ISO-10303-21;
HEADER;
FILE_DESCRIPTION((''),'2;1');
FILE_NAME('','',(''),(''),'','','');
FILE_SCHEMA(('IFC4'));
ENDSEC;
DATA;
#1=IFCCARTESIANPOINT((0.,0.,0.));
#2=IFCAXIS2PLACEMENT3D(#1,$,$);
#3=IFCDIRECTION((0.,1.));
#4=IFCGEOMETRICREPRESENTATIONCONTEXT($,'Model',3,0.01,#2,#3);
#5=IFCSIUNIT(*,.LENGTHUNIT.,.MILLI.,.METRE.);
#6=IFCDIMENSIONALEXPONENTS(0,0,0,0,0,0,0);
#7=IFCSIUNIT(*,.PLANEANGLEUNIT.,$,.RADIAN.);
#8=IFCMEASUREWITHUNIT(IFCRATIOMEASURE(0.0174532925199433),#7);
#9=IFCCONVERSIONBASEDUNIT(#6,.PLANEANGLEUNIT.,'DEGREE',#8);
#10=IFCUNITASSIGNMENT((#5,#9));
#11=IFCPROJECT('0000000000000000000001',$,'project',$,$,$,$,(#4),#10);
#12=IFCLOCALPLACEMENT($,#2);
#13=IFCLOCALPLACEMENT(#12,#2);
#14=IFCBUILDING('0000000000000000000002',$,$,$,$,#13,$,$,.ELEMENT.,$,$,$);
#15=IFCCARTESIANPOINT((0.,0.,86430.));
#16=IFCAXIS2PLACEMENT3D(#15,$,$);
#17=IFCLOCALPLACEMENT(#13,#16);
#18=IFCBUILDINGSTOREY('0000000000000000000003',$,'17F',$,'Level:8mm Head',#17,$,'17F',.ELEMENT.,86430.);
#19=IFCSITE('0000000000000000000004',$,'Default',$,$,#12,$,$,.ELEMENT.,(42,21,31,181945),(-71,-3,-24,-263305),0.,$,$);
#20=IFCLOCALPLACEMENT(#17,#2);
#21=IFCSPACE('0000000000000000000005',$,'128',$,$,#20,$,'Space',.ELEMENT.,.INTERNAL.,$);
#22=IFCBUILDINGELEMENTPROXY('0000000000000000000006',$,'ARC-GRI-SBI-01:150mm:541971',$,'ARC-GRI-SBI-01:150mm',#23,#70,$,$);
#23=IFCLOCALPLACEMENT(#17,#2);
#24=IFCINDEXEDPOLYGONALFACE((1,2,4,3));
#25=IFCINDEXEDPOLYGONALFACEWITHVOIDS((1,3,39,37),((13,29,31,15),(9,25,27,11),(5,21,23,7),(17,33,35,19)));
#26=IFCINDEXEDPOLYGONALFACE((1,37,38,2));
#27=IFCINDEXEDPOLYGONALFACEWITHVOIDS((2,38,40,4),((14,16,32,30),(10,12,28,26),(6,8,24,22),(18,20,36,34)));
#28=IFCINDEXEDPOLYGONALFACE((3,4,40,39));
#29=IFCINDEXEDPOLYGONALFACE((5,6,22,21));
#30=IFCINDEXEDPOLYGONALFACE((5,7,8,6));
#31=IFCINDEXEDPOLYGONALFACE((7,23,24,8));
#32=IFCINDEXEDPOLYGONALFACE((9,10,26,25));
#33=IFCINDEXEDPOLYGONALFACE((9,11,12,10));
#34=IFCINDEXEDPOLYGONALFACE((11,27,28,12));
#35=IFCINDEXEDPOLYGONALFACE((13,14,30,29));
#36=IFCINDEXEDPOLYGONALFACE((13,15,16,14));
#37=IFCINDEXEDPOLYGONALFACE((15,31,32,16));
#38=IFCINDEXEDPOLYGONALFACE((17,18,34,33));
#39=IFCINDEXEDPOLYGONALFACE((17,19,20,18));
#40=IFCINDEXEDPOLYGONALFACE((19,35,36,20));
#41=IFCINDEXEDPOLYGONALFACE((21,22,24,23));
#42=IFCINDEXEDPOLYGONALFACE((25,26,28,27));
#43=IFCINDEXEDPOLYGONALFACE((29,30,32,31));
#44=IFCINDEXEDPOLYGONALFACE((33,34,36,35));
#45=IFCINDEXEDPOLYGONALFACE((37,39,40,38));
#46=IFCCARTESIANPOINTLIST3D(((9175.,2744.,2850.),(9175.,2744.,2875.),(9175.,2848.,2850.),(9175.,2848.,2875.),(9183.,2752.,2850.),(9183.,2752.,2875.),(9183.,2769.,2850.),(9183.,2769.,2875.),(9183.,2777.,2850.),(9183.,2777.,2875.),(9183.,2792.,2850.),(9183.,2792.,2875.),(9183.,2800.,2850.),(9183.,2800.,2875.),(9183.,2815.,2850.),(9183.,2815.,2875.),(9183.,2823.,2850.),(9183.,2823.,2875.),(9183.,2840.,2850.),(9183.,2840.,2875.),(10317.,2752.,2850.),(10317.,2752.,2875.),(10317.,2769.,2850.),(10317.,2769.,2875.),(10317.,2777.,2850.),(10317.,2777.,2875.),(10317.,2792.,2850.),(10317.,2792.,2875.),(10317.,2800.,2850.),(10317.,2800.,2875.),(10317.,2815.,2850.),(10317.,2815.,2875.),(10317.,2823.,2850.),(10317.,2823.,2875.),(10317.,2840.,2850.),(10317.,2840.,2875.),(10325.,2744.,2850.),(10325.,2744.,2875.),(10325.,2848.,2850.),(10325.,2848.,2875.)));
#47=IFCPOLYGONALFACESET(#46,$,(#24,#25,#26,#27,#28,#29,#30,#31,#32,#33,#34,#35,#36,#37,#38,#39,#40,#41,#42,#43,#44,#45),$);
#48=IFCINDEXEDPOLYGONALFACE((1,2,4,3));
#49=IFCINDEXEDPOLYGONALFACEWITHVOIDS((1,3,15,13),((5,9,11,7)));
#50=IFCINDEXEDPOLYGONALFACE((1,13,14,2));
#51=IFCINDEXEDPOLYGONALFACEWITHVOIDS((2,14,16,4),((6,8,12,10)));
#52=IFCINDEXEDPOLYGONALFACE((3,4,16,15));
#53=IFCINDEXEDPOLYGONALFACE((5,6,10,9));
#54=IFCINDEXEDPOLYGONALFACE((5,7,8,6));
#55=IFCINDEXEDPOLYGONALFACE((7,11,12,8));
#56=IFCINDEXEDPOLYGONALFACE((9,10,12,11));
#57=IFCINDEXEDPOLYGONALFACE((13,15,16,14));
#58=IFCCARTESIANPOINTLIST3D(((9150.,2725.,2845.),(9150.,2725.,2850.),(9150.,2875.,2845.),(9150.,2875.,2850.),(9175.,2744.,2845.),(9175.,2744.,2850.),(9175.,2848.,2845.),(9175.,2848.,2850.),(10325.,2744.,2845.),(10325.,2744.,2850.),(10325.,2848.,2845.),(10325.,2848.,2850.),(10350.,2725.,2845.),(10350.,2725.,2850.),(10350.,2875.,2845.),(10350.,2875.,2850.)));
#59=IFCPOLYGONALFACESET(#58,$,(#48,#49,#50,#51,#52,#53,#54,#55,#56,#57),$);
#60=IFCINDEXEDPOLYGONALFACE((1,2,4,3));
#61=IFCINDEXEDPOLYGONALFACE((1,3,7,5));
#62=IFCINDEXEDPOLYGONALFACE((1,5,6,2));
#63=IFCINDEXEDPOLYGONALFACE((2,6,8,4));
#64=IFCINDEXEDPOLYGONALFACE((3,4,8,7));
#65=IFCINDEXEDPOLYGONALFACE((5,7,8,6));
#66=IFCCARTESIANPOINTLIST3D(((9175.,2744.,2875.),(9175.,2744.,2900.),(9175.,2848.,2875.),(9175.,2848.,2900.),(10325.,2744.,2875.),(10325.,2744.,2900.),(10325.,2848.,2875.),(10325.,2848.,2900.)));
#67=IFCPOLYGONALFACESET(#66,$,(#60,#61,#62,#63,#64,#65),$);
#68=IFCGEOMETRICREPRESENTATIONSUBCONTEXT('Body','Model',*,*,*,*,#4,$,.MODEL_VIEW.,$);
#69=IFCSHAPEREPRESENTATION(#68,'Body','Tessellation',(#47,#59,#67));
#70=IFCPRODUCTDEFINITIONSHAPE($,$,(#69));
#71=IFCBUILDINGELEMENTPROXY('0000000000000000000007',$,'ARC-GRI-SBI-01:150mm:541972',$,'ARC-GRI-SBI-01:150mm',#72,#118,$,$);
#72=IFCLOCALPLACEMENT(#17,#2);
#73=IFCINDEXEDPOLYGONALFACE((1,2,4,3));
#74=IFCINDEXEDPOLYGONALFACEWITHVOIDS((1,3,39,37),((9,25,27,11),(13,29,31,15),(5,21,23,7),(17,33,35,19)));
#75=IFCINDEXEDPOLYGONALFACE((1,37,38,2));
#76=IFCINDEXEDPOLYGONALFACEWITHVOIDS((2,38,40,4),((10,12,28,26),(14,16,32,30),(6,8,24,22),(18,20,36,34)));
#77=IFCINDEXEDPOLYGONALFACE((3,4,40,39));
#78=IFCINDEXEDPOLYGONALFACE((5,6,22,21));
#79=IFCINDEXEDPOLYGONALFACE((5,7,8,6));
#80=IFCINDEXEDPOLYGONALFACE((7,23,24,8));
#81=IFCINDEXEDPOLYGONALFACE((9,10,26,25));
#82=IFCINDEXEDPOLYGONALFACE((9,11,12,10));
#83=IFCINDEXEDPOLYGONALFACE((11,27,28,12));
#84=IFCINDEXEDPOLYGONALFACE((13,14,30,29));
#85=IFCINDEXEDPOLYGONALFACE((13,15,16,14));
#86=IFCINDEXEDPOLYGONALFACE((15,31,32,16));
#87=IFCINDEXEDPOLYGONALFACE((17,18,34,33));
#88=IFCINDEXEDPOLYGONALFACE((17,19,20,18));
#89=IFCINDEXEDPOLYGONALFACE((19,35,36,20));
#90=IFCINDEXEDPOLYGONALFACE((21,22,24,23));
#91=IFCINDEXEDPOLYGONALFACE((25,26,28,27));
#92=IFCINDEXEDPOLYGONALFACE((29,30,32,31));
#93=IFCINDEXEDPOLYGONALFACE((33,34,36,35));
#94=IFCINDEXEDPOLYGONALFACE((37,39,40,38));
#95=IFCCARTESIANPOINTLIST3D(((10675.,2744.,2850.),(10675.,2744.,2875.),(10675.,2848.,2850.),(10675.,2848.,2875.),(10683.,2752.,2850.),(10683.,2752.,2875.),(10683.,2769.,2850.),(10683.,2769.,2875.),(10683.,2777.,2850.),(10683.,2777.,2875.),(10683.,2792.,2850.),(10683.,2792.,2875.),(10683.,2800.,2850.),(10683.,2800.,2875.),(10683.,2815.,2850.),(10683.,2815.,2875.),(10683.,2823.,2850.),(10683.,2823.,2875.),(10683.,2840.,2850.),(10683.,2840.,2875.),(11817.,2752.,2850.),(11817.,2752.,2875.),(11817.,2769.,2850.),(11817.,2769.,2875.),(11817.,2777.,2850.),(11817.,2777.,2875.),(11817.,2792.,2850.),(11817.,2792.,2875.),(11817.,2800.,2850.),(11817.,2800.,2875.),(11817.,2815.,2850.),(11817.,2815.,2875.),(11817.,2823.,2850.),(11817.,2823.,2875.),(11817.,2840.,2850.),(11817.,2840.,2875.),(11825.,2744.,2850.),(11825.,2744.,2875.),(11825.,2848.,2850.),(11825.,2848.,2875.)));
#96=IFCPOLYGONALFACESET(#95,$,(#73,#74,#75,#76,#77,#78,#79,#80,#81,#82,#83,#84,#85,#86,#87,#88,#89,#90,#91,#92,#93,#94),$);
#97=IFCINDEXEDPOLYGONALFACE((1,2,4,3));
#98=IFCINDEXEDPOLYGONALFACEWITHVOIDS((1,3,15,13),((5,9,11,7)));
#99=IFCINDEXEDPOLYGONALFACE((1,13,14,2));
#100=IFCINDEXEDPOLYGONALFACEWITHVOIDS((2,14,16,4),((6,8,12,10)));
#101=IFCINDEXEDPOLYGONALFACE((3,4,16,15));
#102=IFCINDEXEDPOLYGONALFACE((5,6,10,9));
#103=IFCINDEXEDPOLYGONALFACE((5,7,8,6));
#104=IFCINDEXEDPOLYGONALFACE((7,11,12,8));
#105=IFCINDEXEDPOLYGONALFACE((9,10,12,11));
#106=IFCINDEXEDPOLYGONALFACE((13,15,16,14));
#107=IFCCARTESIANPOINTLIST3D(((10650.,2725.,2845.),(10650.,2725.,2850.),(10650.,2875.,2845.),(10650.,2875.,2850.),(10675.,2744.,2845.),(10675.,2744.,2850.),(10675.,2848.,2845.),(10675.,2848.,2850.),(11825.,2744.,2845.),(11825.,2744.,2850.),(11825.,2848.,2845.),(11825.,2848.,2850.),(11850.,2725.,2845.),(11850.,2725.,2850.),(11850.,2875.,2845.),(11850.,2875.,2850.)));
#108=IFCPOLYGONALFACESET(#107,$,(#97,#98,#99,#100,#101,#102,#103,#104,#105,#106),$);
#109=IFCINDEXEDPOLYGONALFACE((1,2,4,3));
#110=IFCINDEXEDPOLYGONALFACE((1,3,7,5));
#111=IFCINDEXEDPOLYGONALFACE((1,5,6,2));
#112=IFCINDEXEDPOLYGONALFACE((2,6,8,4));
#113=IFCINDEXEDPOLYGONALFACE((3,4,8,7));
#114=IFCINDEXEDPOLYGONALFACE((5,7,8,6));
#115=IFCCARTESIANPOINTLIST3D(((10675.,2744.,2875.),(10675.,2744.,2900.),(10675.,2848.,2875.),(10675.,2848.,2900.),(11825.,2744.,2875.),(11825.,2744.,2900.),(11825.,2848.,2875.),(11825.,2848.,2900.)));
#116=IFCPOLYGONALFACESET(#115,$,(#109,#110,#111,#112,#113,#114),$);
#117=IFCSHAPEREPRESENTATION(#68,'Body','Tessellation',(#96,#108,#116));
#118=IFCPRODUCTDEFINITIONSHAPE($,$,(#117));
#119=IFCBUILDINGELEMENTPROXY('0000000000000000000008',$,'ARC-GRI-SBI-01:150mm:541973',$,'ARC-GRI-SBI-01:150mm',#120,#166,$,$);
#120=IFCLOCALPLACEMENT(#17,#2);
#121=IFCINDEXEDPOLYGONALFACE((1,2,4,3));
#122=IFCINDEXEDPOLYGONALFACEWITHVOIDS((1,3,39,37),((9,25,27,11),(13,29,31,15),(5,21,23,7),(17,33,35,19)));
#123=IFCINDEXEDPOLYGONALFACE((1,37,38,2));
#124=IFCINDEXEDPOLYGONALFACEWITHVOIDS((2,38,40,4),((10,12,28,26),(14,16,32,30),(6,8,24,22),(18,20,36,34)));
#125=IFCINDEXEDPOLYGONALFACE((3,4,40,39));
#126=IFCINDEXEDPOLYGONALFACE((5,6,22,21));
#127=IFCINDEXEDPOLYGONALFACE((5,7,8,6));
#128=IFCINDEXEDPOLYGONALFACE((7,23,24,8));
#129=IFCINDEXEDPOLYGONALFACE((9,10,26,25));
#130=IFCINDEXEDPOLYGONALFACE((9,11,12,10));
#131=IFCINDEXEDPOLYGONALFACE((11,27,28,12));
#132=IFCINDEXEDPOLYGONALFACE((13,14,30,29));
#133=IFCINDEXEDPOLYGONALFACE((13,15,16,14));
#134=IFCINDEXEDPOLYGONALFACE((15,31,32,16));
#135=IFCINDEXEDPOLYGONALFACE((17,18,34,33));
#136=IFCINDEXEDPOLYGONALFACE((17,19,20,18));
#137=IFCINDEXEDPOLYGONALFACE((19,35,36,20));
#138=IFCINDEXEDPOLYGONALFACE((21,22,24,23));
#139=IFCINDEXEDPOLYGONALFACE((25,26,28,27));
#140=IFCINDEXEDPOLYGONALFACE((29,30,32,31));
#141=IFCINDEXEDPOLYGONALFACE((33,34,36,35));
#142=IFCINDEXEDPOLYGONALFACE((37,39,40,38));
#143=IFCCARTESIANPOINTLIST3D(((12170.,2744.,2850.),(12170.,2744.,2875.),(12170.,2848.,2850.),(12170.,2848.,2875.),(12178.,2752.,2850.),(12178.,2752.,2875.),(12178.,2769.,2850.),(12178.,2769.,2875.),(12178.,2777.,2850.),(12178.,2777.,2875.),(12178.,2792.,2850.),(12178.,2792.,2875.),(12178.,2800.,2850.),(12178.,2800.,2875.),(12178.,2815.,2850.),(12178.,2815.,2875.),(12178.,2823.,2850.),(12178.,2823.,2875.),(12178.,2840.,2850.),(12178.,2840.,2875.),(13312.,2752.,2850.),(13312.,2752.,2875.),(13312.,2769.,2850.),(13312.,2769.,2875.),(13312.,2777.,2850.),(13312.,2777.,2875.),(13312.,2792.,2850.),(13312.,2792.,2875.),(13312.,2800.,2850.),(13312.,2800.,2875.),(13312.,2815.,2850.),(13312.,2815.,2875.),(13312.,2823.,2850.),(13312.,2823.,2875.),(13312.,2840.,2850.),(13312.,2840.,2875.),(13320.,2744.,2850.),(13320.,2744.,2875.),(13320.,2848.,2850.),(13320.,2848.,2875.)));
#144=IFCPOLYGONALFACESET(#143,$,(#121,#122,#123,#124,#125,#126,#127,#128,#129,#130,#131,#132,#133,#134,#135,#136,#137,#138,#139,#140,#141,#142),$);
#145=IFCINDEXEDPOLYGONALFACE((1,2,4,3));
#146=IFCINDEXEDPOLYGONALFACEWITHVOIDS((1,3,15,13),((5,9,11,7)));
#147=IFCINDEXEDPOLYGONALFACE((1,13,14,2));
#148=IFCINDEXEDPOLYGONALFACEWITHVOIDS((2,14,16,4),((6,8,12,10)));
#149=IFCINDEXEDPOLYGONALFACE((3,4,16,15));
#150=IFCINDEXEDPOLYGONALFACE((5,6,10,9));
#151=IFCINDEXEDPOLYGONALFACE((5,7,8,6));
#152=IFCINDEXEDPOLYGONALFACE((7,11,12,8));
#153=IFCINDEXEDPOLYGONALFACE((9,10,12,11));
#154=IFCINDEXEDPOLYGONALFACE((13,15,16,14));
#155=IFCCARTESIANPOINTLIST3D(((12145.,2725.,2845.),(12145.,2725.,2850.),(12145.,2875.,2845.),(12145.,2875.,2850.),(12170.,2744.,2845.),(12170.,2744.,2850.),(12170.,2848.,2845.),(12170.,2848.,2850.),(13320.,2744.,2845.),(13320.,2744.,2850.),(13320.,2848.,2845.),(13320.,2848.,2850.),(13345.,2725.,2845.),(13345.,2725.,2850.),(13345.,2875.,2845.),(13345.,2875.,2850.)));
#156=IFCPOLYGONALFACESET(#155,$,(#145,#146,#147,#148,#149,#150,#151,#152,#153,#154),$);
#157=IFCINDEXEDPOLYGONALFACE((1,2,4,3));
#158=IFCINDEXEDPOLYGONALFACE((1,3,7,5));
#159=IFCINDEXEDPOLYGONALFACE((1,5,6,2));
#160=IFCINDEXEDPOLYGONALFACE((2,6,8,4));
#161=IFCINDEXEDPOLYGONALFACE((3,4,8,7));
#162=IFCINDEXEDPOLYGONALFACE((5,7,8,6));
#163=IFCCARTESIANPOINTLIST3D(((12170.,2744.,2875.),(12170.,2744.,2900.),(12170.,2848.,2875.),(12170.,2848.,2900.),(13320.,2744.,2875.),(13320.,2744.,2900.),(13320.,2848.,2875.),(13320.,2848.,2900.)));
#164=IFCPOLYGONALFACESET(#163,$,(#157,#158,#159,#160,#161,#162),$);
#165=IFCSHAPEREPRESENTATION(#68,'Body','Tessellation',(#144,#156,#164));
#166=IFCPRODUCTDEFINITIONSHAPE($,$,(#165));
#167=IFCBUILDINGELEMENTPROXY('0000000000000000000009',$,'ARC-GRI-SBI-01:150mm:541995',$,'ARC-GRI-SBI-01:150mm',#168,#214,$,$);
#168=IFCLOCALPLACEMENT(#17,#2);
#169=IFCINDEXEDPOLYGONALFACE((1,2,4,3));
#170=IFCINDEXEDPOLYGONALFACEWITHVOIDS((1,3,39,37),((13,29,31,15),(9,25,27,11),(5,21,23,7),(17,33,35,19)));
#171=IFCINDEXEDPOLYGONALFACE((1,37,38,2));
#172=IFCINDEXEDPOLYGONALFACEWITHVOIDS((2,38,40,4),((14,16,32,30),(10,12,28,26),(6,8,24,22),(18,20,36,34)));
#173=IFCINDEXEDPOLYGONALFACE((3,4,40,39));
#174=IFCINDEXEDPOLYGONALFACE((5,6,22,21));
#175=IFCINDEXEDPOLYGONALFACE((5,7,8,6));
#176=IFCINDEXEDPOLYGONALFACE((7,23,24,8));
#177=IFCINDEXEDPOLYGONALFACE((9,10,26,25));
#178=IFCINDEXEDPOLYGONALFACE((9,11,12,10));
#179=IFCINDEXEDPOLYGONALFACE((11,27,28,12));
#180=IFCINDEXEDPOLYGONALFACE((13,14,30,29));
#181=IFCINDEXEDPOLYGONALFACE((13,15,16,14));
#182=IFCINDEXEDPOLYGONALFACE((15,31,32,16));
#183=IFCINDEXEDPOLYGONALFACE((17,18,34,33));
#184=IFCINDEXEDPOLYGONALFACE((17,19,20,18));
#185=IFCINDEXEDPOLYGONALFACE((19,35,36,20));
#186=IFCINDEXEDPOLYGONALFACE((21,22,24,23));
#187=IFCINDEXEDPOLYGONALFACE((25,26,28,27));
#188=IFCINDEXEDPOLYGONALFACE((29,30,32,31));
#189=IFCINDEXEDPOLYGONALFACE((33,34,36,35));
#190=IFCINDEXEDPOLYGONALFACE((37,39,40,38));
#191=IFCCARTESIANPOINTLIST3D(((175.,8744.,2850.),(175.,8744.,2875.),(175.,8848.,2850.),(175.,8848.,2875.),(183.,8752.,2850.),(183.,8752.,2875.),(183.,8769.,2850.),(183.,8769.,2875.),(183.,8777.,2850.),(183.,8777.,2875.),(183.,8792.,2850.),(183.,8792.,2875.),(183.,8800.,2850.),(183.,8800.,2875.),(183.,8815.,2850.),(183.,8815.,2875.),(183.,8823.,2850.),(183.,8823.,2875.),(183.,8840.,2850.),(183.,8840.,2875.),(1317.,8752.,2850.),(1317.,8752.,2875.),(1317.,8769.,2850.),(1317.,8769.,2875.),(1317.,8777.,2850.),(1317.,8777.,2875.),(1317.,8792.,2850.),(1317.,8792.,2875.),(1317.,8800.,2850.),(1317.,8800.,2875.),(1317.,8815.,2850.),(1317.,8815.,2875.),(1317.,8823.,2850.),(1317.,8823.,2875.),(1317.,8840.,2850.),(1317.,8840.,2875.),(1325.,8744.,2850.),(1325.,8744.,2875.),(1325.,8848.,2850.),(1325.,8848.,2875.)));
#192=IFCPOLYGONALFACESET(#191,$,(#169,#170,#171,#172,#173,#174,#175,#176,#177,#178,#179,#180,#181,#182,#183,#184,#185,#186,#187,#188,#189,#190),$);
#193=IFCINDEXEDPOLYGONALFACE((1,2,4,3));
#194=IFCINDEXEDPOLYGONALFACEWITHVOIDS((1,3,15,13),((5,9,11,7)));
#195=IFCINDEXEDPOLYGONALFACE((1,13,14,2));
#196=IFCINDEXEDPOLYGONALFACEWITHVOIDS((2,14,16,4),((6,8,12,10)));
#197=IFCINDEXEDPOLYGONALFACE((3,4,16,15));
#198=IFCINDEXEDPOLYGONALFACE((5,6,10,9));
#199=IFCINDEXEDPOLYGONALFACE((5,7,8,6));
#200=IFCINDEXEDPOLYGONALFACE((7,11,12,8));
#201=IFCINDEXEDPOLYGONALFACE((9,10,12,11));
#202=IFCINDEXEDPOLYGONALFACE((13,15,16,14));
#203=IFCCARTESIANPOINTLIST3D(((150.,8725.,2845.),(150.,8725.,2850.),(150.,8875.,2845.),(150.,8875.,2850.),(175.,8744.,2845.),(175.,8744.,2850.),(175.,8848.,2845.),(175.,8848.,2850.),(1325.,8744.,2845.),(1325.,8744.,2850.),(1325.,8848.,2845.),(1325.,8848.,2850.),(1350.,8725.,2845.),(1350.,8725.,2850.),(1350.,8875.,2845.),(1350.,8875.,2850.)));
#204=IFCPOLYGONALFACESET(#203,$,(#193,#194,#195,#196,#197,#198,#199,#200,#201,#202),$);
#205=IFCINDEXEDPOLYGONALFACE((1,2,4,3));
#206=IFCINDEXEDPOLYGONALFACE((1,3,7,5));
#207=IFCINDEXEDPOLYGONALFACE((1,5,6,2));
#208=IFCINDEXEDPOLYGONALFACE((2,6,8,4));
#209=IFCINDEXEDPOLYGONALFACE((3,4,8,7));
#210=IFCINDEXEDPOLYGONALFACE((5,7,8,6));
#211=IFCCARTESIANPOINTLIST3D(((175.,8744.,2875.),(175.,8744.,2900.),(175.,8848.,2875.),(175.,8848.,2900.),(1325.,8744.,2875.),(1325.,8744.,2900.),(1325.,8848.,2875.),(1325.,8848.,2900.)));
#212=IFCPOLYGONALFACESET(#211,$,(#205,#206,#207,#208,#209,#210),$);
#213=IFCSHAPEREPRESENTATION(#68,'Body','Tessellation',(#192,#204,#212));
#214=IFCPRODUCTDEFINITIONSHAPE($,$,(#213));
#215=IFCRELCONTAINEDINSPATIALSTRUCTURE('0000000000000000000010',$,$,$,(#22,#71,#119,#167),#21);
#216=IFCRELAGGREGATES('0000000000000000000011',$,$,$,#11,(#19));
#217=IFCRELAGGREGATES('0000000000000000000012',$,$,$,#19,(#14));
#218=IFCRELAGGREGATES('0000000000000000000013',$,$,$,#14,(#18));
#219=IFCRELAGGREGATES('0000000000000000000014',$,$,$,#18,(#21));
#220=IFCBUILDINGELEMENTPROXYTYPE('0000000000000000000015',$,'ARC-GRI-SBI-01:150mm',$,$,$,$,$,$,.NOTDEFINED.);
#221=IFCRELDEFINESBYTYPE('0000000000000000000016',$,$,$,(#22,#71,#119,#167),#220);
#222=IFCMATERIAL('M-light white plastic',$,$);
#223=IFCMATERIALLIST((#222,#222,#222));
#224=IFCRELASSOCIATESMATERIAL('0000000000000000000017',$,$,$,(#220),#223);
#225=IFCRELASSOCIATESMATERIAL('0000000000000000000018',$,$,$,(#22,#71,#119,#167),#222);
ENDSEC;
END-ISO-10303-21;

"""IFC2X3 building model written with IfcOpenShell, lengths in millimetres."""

from ifc_helpers import new_model, entity, si_unit, converted_unit, direction, frame, origin, origin_2d_with_axis, place, context, subcontext, project, spatial, polyline, rectangle, outline, extrude, source, transform, mapped, material, material_list, type_object, type_shapes, element, save


model = new_model("IFC2X3")

# Units and contexts
model_context = context("Model", 3, precision=0.01, world=origin(), true_north=direction((0.0, 1.0)))
body_context = subcontext(model_context, "Body", "Model", "MODEL_VIEW")
ifc_project = project(units=[si_unit("LENGTHUNIT", "METRE", prefix="MILLI"), converted_unit("PLANEANGLEUNIT", "DEGREE", entity("IfcRatioMeasure", 0.0174532925199433), si_unit("PLANEANGLEUNIT", "RADIAN"), dimensions=[0, 0, 0, 0, 0, 0, 0])], contexts=[model_context])

# Site, building, storey
site_placement = place(None, origin())
site = spatial("IfcSite", under=ifc_project, at=site_placement, Name="Default", CompositionType="ELEMENT", RefLatitude=(42, 21, 31, 181945), RefLongitude=(-71, -3, -24, -263305), RefElevation=0.0)
building_placement = place(site_placement, origin())
building = spatial("IfcBuilding", under=site, at=building_placement, CompositionType="ELEMENT")
storey_placement = place(building_placement, frame((0.0, 0.0, 86430.0)))
storey = spatial("IfcBuildingStorey", under=building, at=storey_placement, Name="17F", ObjectType="Level:8mm Head", LongName="17F", CompositionType="ELEMENT", Elevation=86430.0)

# Shared definitions
space_placement = place(storey_placement, origin())
space = spatial("IfcSpace", under=storey, at=space_placement, Name="128", LongName="Space", CompositionType="ELEMENT", InteriorOrExteriorSpace="INTERNAL")

# Building element proxies
ifc_material_1 = material(Name="M-light white plastic")
ifc_material_list = material_list([ifc_material_1, ifc_material_1, ifc_material_1])
building_element_proxy_type = type_object("IfcBuildingElementProxyType", Name="ARC-GRI-SBI-01:150mm", PredefinedType="NOTDEFINED", material=ifc_material_list)
shared_shape = source(origin(), body_context, "Body", "SweptSolid", [
    extrude(outline(polyline([(-575.0, -52.0), (575.0, -52.0), (575.0, 52.0), (-575.0, 52.0), (-575.0, -52.0)]), holes=[polyline([(-567.0, -44.0), (-567.0, -27.0), (567.0, -27.0), (567.0, -44.0), (-567.0, -44.0)]), polyline([(567.0, -4.0), (567.0, -19.0), (-567.0, -19.0), (-567.0, -4.0), (567.0, -4.0)]), polyline([(-567.0, 44.0), (567.0, 44.0), (567.0, 27.0), (-567.0, 27.0), (-567.0, 44.0)]), polyline([(567.0, 4.0), (-567.0, 4.0), (-567.0, 19.0), (567.0, 19.0), (567.0, 4.0)])]), frame((425.0, 4.0, 4000.0), z_axis=(0.0, 0.0, 1.0), x_axis=(-1.0, 0.0, 0.0)), (0.0, 0.0, 1.0), 25.0),
    extrude(outline(polyline([(-600.0, -75.0), (600.0, -75.0), (600.0, 75.0), (-600.0, 75.0), (-600.0, -75.0)]), holes=[polyline([(-575.0, -56.0), (-575.0, 48.0), (575.0, 48.0), (575.0, -56.0), (-575.0, -56.0)])]), frame((425.0, 0.0, 3995.0), z_axis=(0.0, 0.0, 1.0), x_axis=(-1.0, 0.0, 0.0)), (0.0, 0.0, 1.0), 5.0),
    extrude(rectangle(XDim=1150.0, YDim=104.0, at=origin_2d_with_axis()), frame((425.0, 4.0, 4025.0), z_axis=(0.0, 0.0, 1.0), x_axis=(-1.0, 0.0, 0.0)), (0.0, 0.0, 1.0), 25.0),
])
type_shapes(building_element_proxy_type, [shared_shape])
for number, where, z_axis, x_axis, name in (
    (1, (10175.0, 2800.0, -1150.0), (0.0, 0.0, 1.0), (-1.0, 0.0, 0.0), "ARC-GRI-SBI-01:150mm:541971"),
    (2, (11675.0, 2800.0, -1150.0), (0.0, 0.0, 1.0), (-1.0, 0.0, 0.0), "ARC-GRI-SBI-01:150mm:541972"),
    (3, (13170.0, 2800.0, -1150.0), (0.0, 0.0, 1.0), (-1.0, 0.0, 0.0), "ARC-GRI-SBI-01:150mm:541973"),
    (4, (1175.0, 8800.0, -1150.0), (0.0, 0.0, 1.0), (-1.0, 0.0, 0.0), "ARC-GRI-SBI-01:150mm:541995"),
):
    element("IfcBuildingElementProxy", number, at=place(space_placement, frame(where, z_axis=z_axis, x_axis=x_axis)), inside=space, type_object=building_element_proxy_type, material=ifc_material_1, Name=name, ObjectType="ARC-GRI-SBI-01:150mm", context=body_context, shape_type="MappedRepresentation", body=[
        mapped(shared_shape, transform((0.0, 0.0, 0.0), scale=1.0)),
    ])

save(model, "model.ifc")
